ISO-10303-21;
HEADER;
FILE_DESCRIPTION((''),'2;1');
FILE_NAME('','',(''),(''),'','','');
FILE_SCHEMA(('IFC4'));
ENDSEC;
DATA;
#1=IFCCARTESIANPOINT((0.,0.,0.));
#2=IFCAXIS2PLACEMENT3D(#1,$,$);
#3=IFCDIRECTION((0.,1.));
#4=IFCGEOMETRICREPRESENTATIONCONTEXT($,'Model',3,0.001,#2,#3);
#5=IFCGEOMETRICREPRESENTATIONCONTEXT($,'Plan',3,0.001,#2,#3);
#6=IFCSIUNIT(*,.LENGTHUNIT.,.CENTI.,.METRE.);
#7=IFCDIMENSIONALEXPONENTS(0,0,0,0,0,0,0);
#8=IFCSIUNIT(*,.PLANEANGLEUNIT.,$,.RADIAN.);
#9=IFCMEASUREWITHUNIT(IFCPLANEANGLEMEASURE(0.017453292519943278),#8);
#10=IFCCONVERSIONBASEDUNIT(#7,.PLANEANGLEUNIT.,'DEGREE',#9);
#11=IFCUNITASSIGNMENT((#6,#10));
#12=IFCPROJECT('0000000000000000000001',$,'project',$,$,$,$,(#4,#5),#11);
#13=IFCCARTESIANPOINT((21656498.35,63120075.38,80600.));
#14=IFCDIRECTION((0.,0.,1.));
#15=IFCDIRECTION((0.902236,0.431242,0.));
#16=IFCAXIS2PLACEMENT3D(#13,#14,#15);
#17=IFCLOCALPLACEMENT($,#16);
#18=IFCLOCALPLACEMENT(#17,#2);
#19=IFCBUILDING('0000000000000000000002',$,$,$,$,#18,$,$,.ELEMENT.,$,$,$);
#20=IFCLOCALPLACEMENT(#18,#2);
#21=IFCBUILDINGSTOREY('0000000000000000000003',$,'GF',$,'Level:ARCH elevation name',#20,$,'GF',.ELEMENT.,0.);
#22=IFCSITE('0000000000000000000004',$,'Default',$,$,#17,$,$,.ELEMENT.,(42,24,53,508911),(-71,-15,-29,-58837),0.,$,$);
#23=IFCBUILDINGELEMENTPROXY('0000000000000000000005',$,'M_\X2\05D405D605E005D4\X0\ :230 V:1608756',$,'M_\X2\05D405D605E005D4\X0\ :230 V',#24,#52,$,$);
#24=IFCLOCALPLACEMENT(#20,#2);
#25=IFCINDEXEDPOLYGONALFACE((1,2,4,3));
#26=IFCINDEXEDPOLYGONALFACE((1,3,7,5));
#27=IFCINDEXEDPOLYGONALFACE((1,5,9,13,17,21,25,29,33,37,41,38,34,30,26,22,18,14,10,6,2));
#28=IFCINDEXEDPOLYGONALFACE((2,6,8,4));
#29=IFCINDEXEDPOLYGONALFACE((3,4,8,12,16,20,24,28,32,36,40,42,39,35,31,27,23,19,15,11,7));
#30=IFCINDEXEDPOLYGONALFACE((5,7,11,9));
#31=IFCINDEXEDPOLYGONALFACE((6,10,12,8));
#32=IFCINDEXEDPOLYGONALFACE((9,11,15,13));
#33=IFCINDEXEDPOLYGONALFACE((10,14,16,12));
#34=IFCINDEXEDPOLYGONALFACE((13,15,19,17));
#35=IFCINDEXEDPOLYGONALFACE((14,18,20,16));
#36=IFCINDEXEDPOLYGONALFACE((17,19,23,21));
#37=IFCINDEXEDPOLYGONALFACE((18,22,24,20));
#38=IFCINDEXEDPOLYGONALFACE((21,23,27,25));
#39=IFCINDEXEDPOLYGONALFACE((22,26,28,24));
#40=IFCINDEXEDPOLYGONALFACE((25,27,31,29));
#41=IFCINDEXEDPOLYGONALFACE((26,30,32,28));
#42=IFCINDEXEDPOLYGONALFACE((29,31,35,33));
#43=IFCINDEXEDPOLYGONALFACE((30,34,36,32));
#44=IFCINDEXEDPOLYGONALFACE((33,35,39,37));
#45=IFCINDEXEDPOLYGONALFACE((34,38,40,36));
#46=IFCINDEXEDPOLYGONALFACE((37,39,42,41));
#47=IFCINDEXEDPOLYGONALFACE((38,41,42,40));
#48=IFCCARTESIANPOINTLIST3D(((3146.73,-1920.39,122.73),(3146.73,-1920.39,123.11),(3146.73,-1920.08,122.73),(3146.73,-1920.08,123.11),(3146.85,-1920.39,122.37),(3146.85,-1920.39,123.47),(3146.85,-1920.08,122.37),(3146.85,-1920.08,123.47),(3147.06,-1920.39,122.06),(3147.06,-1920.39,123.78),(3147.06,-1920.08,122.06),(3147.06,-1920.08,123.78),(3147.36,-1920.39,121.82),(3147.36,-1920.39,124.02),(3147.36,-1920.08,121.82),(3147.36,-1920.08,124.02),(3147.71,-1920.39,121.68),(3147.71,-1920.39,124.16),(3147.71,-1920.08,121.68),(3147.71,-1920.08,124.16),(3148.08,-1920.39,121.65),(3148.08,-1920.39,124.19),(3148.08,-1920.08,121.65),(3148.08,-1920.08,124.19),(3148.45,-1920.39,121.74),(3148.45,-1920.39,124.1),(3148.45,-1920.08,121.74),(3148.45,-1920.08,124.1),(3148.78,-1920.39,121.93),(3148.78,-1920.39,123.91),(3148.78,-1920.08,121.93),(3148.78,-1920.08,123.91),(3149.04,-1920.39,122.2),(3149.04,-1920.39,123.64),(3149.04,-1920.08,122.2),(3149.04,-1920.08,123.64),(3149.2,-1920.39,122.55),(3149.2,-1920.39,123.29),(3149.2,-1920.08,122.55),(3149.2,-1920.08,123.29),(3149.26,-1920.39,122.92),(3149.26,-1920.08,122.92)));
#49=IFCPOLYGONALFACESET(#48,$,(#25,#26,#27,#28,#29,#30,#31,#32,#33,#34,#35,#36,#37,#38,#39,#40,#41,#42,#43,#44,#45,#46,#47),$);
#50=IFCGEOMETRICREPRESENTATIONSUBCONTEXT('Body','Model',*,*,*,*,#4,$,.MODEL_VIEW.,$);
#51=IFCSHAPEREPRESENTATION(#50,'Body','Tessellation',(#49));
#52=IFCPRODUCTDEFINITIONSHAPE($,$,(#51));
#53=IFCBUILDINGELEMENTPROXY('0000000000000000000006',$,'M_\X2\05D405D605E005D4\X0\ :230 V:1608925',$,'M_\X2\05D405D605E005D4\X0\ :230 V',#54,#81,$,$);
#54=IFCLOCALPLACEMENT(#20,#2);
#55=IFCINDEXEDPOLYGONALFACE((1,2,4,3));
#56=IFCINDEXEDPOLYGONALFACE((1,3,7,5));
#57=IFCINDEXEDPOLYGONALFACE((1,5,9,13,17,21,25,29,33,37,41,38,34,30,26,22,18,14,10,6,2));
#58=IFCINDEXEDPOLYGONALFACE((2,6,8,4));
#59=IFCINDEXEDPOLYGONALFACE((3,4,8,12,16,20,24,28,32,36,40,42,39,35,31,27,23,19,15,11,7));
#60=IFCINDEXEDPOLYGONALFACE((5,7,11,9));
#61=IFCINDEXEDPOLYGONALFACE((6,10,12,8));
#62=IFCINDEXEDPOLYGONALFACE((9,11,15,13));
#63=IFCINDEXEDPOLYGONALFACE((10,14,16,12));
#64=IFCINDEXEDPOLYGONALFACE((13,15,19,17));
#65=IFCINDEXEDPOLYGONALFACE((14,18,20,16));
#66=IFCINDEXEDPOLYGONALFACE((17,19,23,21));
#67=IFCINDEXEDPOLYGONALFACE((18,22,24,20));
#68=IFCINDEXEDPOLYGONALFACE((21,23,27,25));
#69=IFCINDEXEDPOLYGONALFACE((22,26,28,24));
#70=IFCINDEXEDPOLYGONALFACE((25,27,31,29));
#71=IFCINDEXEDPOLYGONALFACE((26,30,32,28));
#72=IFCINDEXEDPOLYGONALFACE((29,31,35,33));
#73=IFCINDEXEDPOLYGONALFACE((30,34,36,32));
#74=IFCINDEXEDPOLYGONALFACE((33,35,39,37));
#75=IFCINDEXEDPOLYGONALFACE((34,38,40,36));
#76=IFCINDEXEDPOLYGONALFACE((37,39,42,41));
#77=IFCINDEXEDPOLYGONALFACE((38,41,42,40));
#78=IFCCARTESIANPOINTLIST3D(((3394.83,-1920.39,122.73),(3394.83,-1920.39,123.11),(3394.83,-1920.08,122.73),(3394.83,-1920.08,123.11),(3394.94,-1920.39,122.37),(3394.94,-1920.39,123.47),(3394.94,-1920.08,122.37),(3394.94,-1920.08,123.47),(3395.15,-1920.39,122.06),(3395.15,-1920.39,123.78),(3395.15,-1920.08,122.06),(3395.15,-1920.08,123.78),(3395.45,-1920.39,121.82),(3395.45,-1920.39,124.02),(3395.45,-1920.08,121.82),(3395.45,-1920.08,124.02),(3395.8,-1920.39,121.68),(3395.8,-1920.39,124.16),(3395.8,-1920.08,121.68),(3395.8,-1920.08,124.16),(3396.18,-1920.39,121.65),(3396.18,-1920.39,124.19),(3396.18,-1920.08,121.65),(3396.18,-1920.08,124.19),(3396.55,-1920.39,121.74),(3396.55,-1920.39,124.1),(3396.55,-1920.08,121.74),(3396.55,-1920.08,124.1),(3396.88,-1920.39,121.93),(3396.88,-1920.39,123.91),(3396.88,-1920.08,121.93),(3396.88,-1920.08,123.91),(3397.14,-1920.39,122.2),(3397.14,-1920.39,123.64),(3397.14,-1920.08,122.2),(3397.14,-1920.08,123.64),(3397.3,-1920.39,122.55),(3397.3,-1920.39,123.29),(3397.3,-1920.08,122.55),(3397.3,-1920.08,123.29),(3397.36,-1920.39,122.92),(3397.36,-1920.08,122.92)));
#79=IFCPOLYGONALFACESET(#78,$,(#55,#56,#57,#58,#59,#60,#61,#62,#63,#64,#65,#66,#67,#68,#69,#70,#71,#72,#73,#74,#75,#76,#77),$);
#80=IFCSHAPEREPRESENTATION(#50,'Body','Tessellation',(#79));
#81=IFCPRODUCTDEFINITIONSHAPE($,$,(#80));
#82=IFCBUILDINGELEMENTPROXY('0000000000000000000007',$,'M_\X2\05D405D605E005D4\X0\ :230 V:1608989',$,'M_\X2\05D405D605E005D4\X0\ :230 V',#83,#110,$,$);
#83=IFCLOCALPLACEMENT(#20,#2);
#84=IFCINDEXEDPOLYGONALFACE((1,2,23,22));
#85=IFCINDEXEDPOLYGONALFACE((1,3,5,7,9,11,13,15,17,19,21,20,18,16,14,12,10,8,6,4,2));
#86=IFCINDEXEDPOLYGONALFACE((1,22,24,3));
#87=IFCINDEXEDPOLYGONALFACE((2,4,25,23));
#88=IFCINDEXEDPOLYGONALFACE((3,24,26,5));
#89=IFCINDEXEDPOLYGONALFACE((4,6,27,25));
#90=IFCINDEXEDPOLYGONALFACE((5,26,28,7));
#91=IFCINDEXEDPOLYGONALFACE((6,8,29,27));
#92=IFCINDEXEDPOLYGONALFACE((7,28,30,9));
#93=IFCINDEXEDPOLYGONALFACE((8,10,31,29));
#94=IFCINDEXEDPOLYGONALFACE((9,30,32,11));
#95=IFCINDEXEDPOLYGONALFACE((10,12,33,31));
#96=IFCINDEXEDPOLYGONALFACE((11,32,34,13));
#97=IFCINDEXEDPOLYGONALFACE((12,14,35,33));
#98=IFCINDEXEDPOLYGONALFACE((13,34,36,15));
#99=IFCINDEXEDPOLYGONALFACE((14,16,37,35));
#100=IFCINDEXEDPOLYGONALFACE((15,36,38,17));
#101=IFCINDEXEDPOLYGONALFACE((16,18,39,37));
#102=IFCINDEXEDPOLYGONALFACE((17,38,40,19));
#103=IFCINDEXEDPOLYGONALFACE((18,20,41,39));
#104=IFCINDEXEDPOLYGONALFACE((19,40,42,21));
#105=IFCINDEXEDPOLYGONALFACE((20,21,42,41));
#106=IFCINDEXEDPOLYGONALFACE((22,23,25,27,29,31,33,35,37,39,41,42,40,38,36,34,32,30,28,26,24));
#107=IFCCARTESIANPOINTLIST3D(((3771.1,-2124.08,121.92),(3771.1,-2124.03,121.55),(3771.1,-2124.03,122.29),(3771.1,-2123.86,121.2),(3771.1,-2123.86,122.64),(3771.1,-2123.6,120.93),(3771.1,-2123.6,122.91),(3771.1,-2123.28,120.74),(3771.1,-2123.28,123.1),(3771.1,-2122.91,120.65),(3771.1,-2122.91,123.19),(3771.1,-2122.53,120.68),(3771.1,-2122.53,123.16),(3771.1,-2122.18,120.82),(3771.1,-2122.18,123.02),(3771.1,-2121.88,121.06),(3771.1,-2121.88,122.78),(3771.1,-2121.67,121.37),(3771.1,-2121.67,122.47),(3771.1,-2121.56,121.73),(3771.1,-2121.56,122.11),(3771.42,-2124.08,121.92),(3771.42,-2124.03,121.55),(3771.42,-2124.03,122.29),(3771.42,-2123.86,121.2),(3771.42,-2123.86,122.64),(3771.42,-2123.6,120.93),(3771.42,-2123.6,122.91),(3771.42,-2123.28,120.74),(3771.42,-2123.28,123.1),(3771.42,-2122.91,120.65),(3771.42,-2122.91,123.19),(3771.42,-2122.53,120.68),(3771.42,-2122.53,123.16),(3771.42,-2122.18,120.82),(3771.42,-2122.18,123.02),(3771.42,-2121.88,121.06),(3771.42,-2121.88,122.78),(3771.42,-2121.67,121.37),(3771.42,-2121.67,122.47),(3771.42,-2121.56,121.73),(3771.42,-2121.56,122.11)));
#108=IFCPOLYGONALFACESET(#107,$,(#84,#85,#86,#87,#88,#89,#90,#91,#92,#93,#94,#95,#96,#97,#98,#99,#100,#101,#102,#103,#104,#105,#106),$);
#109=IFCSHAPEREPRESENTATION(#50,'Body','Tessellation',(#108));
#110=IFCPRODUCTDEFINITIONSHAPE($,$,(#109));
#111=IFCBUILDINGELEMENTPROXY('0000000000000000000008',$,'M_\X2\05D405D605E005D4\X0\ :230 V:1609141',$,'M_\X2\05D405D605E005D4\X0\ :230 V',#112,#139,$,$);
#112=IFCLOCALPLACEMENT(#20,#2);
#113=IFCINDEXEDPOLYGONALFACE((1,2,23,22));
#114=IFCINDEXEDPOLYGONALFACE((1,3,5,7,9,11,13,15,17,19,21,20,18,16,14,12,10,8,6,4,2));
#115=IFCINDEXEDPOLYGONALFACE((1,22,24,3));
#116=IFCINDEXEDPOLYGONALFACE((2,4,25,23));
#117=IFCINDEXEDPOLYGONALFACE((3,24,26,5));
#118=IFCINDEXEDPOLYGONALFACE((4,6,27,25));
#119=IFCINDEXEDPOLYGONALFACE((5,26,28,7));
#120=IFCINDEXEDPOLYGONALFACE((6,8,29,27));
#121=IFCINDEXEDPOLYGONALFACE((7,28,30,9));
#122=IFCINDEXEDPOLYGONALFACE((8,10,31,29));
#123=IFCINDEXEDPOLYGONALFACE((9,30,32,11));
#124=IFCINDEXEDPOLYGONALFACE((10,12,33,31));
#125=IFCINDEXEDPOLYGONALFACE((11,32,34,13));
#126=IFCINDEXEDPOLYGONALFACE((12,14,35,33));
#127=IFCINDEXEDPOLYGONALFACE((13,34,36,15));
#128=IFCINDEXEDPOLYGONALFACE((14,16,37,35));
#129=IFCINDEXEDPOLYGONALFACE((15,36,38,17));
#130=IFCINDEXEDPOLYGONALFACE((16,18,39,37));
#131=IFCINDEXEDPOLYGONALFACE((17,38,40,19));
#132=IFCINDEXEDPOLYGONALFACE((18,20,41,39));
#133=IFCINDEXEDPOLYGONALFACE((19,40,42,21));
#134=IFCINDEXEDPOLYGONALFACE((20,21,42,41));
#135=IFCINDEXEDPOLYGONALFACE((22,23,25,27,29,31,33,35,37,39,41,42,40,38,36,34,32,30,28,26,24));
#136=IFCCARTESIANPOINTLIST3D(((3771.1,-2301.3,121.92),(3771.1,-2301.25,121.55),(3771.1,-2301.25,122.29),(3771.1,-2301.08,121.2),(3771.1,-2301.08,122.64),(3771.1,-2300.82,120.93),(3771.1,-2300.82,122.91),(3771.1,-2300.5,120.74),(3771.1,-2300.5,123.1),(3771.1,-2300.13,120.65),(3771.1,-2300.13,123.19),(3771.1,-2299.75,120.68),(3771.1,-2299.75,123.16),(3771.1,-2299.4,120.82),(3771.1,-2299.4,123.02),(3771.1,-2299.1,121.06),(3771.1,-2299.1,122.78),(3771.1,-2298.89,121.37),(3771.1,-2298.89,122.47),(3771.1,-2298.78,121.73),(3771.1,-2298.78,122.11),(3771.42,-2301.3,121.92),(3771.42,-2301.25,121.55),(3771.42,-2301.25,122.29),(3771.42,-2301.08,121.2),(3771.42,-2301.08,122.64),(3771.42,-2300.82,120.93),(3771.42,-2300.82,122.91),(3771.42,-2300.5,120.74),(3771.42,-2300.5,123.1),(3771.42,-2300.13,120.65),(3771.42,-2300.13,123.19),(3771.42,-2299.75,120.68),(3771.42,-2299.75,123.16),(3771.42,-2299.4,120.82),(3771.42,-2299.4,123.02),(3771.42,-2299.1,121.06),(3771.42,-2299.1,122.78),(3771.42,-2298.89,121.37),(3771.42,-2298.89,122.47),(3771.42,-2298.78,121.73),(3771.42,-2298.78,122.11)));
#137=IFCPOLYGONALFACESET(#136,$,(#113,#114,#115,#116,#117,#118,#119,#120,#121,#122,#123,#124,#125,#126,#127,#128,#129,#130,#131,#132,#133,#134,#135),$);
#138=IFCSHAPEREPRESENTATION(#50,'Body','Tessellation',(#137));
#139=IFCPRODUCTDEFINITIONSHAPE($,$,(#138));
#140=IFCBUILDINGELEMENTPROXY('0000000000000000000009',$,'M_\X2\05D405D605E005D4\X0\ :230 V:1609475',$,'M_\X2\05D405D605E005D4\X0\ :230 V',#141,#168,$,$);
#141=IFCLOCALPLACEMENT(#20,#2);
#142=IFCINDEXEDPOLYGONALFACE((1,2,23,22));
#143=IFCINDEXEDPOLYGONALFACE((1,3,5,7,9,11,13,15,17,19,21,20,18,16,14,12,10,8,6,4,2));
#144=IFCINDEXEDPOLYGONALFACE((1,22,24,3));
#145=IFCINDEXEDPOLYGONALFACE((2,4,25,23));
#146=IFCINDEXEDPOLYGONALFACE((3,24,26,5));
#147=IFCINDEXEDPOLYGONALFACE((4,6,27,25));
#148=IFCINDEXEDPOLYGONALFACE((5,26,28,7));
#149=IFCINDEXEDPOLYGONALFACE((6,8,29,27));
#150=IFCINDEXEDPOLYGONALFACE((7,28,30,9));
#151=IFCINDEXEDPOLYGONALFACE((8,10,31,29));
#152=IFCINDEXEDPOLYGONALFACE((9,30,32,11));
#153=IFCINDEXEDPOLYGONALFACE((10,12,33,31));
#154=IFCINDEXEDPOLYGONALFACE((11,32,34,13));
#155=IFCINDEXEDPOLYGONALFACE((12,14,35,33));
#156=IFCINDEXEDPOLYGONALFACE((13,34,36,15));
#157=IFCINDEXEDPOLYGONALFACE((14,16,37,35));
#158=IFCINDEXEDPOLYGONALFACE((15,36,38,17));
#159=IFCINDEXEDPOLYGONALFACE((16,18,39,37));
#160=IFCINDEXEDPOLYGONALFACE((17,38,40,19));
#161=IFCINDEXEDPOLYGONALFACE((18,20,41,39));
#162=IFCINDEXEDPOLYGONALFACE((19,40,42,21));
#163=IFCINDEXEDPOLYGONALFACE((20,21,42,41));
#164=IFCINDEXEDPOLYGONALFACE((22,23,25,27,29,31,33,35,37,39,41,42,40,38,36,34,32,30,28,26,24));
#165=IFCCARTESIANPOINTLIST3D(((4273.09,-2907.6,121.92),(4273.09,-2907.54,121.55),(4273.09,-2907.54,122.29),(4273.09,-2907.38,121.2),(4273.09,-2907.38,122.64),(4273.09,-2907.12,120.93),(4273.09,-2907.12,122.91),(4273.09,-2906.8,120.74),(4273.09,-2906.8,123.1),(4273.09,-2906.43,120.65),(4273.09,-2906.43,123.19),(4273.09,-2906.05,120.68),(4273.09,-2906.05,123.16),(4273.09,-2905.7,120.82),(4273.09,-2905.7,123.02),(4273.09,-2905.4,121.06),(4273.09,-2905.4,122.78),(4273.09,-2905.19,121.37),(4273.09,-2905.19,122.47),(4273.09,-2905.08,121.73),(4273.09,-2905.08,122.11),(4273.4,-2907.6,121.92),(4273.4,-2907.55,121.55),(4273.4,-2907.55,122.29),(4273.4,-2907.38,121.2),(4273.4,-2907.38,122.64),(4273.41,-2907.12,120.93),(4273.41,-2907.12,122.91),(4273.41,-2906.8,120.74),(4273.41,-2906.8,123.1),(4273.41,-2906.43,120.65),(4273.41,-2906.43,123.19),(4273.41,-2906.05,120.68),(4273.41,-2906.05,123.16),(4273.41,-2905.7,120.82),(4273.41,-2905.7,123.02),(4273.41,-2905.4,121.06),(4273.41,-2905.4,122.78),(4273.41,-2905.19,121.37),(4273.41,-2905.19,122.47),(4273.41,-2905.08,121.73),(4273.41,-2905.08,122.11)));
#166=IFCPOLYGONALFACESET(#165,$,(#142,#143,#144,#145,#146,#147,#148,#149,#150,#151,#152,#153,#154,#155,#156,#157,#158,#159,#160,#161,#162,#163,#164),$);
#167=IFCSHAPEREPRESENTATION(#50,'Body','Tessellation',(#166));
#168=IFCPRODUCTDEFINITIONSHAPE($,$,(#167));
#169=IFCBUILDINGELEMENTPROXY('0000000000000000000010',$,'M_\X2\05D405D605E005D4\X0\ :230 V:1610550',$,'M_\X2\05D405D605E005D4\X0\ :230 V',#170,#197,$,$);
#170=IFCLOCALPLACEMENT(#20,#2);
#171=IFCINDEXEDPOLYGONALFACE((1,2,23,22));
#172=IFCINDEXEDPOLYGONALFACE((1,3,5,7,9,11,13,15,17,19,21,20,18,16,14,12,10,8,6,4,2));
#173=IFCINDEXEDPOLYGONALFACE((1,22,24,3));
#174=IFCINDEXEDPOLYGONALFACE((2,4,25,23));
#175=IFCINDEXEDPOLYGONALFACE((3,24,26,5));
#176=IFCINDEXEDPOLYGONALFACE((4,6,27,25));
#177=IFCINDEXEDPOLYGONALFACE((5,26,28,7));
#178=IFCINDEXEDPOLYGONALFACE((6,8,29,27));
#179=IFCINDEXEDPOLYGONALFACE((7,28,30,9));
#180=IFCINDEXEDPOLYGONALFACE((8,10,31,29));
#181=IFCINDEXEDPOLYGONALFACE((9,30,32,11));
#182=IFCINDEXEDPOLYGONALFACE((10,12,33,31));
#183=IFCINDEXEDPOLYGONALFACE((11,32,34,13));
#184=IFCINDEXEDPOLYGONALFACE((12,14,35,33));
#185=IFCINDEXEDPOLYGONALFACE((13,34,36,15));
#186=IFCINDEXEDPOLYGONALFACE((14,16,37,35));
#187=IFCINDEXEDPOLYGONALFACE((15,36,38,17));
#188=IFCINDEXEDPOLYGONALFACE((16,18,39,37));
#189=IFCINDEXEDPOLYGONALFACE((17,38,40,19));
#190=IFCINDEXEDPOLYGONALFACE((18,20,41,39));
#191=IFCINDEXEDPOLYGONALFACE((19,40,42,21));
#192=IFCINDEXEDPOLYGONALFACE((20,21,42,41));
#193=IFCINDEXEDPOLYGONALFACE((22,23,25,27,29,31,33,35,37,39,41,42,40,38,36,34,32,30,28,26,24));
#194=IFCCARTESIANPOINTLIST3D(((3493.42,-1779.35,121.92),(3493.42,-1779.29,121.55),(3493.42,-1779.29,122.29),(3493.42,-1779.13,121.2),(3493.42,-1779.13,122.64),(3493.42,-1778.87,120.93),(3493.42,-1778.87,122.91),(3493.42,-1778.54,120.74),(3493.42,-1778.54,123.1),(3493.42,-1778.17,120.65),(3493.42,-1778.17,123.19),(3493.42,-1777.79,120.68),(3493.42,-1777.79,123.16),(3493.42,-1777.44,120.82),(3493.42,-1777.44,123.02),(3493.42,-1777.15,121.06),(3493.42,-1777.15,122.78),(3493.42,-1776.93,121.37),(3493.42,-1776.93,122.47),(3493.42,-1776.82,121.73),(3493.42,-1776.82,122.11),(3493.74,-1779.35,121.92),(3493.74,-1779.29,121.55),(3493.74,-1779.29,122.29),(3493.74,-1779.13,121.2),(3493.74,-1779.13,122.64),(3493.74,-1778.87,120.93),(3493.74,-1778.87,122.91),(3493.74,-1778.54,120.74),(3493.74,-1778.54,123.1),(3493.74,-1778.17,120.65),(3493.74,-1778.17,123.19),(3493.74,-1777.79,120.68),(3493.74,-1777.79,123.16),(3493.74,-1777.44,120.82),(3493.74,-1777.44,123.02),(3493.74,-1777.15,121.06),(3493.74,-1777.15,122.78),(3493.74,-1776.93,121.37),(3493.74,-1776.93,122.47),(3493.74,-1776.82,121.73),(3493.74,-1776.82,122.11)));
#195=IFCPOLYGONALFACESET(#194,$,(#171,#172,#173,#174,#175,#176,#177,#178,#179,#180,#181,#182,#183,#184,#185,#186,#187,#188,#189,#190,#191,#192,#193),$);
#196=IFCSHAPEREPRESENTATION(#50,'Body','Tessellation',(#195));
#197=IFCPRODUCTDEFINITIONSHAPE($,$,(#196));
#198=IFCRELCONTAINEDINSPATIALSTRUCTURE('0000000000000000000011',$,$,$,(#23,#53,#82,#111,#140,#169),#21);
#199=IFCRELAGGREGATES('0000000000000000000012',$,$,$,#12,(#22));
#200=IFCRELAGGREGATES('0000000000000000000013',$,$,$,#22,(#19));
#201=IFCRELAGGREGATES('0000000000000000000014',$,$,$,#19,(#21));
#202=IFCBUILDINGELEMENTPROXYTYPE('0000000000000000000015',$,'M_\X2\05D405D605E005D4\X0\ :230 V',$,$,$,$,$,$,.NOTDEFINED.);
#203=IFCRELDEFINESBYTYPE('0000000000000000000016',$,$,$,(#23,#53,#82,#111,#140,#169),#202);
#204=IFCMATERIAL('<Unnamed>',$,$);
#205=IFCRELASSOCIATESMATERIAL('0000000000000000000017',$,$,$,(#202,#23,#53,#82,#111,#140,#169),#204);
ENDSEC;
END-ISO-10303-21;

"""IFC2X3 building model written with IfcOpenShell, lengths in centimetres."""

from ifc_helpers import new_model, entity, si_unit, converted_unit, direction, frame, frame_2d, origin, place, context, subcontext, project, spatial, circle, extrude, source, transform, mapped, material, type_object, type_shapes, element, save


model = new_model("IFC2X3")

# Units and contexts
model_context = context("Model", 3, precision=0.001, world=origin(), true_north=direction((0.0, 1.0)))
plan_context = context("Plan", 3, precision=0.001, world=origin(), true_north=direction((0.0, 1.0)))
body_context = subcontext(model_context, "Body", "Model", "MODEL_VIEW")
ifc_project = project(units=[si_unit("LENGTHUNIT", "METRE", prefix="CENTI"), converted_unit("PLANEANGLEUNIT", "DEGREE", entity("IfcPlaneAngleMeasure", 0.017453292519943278), si_unit("PLANEANGLEUNIT", "RADIAN"), dimensions=[0, 0, 0, 0, 0, 0, 0])], contexts=[model_context, plan_context])

# Site, building, storey
site_placement = place(None, frame((21656498.35, 63120075.38, 80600.0), z_axis=(0.0, 0.0, 1.0), x_axis=(0.902236, 0.431242, 0.0)))
site = spatial("IfcSite", under=ifc_project, at=site_placement, Name="Default", CompositionType="ELEMENT", RefLatitude=(42, 24, 53, 508911), RefLongitude=(-71, -15, -29, -58837), RefElevation=0.0)
building_placement = place(site_placement, origin())
building = spatial("IfcBuilding", under=site, at=building_placement, CompositionType="ELEMENT")
storey_placement = place(building_placement, origin())
storey = spatial("IfcBuildingStorey", under=building, at=storey_placement, Name="GF", ObjectType="Level:ARCH elevation name", LongName="GF", CompositionType="ELEMENT", Elevation=0.0)

# Building element proxies
ifc_material_1 = material(Name="<Unnamed>")
building_element_proxy_type_1 = type_object("IfcBuildingElementProxyType", Name="M_הזנה :230 V", PredefinedType="NOTDEFINED", material=ifc_material_1)
shared_shape_1 = source(origin(), body_context, "Body", "SweptSolid", [
    extrude(circle(Radius=1.27, at=frame_2d((0.0, 0.0), x_axis=(1.0, 0.0))), origin(), (0.0, 0.0, 1.0), 0.32),
])
type_shapes(building_element_proxy_type_1, [shared_shape_1])
for number, where, z_axis, x_axis, name in (
    (1, (3147.99, -1920.08, 122.92), (0.0, -1.0, 0.0), (1.0, 0.0, 0.0), "M_הזנה :230 V:1608756"),
    (2, (3396.09, -1920.08, 122.92), (0.0, -1.0, 0.0), (1.0, 0.0, 0.0), "M_הזנה :230 V:1608925"),
    (3, (3771.42, -2122.81, 121.92), (-1.0, 0.0, 0.0), (0.0, -1.0, 0.0), "M_הזנה :230 V:1608989"),
    (4, (3771.42, -2300.03, 121.92), (-1.0, 0.0, 0.0), (0.0, -1.0, 0.0), "M_הזנה :230 V:1609141"),
    (5, (4273.41, -2906.33, 121.92), (-0.999997, 0.002623, 0.0), (-0.002623, -0.999997, 0.0), "M_הזנה :230 V:1609475"),
    (6, (3493.74, -1778.08, 121.92), (-1.0, 0.0, 0.0), (0.0, -1.0, 0.0), "M_הזנה :230 V:1610550"),
):
    element("IfcBuildingElementProxy", number, at=place(storey_placement, frame(where, z_axis=z_axis, x_axis=x_axis)), inside=storey, type_object=building_element_proxy_type_1, material=ifc_material_1, Name=name, ObjectType="M_הזנה :230 V", context=body_context, shape_type="MappedRepresentation", body=[
        mapped(shared_shape_1, transform((0.0, 0.0, 0.0), scale=1.0)),
    ])

save(model, "model.ifc")
